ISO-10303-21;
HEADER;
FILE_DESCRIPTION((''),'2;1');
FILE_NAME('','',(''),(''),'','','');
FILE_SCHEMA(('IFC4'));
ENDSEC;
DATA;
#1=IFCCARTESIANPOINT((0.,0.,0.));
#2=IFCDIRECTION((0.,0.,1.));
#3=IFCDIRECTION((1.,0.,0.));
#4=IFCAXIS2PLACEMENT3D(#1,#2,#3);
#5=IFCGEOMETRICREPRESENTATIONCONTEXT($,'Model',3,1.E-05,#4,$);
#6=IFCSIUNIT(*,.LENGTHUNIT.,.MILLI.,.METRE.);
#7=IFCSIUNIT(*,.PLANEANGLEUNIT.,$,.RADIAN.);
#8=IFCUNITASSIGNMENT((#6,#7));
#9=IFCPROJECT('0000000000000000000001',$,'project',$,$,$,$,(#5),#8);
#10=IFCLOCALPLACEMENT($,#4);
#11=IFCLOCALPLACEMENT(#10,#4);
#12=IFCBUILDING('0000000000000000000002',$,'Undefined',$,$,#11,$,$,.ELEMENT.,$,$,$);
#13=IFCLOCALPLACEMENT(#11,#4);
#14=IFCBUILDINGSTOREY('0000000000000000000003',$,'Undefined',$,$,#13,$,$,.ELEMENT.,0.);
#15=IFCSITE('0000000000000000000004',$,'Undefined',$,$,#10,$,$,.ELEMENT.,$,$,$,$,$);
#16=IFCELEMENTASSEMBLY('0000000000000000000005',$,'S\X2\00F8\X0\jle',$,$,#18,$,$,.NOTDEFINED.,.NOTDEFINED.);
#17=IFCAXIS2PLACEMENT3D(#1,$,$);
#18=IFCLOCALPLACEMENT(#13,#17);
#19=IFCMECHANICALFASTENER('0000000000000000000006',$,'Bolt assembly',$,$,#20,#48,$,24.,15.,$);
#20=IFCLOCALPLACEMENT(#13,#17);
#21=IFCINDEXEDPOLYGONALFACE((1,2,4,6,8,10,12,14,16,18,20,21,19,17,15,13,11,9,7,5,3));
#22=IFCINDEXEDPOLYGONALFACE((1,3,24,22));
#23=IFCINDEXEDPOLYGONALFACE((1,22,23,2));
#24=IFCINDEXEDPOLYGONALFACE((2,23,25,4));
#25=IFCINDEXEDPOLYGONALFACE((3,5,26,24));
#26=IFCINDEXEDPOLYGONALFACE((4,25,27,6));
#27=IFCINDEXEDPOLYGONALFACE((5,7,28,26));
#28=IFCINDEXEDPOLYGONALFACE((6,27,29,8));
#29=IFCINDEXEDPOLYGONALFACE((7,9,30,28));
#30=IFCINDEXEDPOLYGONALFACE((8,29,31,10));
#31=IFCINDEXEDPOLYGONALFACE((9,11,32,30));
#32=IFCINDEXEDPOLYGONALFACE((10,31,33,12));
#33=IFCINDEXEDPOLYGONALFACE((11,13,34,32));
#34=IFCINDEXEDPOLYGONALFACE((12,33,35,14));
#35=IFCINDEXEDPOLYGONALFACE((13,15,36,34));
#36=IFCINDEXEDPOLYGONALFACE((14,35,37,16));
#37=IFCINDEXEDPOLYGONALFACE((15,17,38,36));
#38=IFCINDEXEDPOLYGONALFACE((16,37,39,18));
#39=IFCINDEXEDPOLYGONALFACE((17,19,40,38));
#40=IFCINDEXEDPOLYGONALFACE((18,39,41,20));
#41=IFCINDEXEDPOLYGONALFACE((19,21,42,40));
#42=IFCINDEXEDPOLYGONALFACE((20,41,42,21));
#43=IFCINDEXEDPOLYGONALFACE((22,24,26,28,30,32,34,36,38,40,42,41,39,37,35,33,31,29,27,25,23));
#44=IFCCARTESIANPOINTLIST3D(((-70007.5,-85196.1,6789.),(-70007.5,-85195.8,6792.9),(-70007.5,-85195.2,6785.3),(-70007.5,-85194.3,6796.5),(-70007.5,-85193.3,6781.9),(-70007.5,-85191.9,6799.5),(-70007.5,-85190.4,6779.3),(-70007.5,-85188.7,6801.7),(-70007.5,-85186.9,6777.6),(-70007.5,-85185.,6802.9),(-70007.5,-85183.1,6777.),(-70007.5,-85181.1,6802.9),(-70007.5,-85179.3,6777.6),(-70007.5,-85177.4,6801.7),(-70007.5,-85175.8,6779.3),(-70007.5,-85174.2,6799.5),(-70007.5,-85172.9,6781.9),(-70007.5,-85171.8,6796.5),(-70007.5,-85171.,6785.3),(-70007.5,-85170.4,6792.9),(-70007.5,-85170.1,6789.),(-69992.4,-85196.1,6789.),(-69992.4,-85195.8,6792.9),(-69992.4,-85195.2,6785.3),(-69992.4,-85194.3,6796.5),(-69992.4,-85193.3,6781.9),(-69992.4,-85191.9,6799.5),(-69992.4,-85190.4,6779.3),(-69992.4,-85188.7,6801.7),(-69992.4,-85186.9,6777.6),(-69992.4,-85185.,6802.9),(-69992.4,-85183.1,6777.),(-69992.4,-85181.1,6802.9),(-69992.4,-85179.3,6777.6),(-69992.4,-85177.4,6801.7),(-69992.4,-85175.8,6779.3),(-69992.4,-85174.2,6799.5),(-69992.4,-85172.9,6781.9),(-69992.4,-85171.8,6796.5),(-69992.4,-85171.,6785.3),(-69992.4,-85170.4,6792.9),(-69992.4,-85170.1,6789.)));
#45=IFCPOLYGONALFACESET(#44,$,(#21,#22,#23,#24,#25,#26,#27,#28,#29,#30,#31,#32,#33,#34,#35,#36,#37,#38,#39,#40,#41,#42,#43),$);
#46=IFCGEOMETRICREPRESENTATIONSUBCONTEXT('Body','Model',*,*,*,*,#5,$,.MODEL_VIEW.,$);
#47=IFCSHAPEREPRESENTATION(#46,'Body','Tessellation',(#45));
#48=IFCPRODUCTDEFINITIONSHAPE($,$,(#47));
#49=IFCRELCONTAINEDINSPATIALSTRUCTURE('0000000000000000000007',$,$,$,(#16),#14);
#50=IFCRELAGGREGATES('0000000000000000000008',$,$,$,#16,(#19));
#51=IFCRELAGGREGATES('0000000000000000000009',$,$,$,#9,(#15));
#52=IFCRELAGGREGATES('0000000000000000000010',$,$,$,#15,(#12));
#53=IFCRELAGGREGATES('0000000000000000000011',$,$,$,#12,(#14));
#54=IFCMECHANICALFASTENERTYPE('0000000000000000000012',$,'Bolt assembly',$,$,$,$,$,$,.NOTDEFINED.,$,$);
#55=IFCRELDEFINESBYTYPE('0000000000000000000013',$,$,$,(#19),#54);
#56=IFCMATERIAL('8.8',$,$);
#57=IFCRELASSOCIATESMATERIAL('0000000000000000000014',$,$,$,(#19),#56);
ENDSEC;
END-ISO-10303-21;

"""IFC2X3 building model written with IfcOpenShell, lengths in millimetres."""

from ifc_helpers import new_model, si_unit, frame, origin_with_axes, origin_2d_with_axis, place, context, subcontext, project, spatial, circle, extrude, source, transform, mapped, material, type_object, element, aggregate, save


model = new_model("IFC2X3")

# Units and contexts
model_context = context("Model", 3, precision=1e-05, world=origin_with_axes())
body_context = subcontext(model_context, "Body", "Model", "MODEL_VIEW")
ifc_project = project(units=[si_unit("LENGTHUNIT", "METRE", prefix="MILLI"), si_unit("PLANEANGLEUNIT", "RADIAN")], contexts=[model_context])

# Site, building, storey
site_placement = place(None, origin_with_axes())
site = spatial("IfcSite", under=ifc_project, at=site_placement, Name="Undefined", CompositionType="ELEMENT")
building_placement = place(site_placement, origin_with_axes())
building = spatial("IfcBuilding", under=site, at=building_placement, Name="Undefined", CompositionType="ELEMENT")
storey_placement = place(building_placement, origin_with_axes())
storey = spatial("IfcBuildingStorey", under=building, at=storey_placement, Name="Undefined", CompositionType="ELEMENT", Elevation=0.0)

# Element assembly
assembly_1_placement = place(storey_placement, origin_with_axes())
assembly_1 = element("IfcElementAssembly", 1, at=assembly_1_placement, inside=storey, Name="Søjle", AssemblyPlace="NOTDEFINED", PredefinedType="NOTDEFINED")

# Shared definitions
ifc_material_1 = material(Name="8.8")
mechanical_fastener_type = type_object("IfcMechanicalFastenerType", Name="Bolt assembly")

# Mechanical fastener
shared_shape_1 = source(origin_with_axes(), body_context, "Body", "SweptSolid", [
    extrude(circle(Radius=13.0, at=origin_2d_with_axis()), frame((0.0, -7.5, 0.0), z_axis=(0.0, 1.0, 0.0), x_axis=(1.0, 0.0, 0.0)), (0.0, 0.0, 1.0), 15.1),
])
mechanical_fastener_1_placement = place(assembly_1_placement, frame((-70000.0, -85183.1, 6790.0), z_axis=(0.0, -1.0, 0.0), x_axis=(0.0, 0.0, -1.0)))
mechanical_fastener_1 = element("IfcMechanicalFastener", 2, at=mechanical_fastener_1_placement, type_object=mechanical_fastener_type, material=ifc_material_1, Name="Bolt assembly", NominalDiameter=24.0, NominalLength=15.0, context=body_context, shape_type="MappedRepresentation", body=[
    mapped(shared_shape_1, transform((0.0, 0.0, 0.0))),
])
aggregate(assembly_1, [mechanical_fastener_1])

save(model, "model.ifc")
